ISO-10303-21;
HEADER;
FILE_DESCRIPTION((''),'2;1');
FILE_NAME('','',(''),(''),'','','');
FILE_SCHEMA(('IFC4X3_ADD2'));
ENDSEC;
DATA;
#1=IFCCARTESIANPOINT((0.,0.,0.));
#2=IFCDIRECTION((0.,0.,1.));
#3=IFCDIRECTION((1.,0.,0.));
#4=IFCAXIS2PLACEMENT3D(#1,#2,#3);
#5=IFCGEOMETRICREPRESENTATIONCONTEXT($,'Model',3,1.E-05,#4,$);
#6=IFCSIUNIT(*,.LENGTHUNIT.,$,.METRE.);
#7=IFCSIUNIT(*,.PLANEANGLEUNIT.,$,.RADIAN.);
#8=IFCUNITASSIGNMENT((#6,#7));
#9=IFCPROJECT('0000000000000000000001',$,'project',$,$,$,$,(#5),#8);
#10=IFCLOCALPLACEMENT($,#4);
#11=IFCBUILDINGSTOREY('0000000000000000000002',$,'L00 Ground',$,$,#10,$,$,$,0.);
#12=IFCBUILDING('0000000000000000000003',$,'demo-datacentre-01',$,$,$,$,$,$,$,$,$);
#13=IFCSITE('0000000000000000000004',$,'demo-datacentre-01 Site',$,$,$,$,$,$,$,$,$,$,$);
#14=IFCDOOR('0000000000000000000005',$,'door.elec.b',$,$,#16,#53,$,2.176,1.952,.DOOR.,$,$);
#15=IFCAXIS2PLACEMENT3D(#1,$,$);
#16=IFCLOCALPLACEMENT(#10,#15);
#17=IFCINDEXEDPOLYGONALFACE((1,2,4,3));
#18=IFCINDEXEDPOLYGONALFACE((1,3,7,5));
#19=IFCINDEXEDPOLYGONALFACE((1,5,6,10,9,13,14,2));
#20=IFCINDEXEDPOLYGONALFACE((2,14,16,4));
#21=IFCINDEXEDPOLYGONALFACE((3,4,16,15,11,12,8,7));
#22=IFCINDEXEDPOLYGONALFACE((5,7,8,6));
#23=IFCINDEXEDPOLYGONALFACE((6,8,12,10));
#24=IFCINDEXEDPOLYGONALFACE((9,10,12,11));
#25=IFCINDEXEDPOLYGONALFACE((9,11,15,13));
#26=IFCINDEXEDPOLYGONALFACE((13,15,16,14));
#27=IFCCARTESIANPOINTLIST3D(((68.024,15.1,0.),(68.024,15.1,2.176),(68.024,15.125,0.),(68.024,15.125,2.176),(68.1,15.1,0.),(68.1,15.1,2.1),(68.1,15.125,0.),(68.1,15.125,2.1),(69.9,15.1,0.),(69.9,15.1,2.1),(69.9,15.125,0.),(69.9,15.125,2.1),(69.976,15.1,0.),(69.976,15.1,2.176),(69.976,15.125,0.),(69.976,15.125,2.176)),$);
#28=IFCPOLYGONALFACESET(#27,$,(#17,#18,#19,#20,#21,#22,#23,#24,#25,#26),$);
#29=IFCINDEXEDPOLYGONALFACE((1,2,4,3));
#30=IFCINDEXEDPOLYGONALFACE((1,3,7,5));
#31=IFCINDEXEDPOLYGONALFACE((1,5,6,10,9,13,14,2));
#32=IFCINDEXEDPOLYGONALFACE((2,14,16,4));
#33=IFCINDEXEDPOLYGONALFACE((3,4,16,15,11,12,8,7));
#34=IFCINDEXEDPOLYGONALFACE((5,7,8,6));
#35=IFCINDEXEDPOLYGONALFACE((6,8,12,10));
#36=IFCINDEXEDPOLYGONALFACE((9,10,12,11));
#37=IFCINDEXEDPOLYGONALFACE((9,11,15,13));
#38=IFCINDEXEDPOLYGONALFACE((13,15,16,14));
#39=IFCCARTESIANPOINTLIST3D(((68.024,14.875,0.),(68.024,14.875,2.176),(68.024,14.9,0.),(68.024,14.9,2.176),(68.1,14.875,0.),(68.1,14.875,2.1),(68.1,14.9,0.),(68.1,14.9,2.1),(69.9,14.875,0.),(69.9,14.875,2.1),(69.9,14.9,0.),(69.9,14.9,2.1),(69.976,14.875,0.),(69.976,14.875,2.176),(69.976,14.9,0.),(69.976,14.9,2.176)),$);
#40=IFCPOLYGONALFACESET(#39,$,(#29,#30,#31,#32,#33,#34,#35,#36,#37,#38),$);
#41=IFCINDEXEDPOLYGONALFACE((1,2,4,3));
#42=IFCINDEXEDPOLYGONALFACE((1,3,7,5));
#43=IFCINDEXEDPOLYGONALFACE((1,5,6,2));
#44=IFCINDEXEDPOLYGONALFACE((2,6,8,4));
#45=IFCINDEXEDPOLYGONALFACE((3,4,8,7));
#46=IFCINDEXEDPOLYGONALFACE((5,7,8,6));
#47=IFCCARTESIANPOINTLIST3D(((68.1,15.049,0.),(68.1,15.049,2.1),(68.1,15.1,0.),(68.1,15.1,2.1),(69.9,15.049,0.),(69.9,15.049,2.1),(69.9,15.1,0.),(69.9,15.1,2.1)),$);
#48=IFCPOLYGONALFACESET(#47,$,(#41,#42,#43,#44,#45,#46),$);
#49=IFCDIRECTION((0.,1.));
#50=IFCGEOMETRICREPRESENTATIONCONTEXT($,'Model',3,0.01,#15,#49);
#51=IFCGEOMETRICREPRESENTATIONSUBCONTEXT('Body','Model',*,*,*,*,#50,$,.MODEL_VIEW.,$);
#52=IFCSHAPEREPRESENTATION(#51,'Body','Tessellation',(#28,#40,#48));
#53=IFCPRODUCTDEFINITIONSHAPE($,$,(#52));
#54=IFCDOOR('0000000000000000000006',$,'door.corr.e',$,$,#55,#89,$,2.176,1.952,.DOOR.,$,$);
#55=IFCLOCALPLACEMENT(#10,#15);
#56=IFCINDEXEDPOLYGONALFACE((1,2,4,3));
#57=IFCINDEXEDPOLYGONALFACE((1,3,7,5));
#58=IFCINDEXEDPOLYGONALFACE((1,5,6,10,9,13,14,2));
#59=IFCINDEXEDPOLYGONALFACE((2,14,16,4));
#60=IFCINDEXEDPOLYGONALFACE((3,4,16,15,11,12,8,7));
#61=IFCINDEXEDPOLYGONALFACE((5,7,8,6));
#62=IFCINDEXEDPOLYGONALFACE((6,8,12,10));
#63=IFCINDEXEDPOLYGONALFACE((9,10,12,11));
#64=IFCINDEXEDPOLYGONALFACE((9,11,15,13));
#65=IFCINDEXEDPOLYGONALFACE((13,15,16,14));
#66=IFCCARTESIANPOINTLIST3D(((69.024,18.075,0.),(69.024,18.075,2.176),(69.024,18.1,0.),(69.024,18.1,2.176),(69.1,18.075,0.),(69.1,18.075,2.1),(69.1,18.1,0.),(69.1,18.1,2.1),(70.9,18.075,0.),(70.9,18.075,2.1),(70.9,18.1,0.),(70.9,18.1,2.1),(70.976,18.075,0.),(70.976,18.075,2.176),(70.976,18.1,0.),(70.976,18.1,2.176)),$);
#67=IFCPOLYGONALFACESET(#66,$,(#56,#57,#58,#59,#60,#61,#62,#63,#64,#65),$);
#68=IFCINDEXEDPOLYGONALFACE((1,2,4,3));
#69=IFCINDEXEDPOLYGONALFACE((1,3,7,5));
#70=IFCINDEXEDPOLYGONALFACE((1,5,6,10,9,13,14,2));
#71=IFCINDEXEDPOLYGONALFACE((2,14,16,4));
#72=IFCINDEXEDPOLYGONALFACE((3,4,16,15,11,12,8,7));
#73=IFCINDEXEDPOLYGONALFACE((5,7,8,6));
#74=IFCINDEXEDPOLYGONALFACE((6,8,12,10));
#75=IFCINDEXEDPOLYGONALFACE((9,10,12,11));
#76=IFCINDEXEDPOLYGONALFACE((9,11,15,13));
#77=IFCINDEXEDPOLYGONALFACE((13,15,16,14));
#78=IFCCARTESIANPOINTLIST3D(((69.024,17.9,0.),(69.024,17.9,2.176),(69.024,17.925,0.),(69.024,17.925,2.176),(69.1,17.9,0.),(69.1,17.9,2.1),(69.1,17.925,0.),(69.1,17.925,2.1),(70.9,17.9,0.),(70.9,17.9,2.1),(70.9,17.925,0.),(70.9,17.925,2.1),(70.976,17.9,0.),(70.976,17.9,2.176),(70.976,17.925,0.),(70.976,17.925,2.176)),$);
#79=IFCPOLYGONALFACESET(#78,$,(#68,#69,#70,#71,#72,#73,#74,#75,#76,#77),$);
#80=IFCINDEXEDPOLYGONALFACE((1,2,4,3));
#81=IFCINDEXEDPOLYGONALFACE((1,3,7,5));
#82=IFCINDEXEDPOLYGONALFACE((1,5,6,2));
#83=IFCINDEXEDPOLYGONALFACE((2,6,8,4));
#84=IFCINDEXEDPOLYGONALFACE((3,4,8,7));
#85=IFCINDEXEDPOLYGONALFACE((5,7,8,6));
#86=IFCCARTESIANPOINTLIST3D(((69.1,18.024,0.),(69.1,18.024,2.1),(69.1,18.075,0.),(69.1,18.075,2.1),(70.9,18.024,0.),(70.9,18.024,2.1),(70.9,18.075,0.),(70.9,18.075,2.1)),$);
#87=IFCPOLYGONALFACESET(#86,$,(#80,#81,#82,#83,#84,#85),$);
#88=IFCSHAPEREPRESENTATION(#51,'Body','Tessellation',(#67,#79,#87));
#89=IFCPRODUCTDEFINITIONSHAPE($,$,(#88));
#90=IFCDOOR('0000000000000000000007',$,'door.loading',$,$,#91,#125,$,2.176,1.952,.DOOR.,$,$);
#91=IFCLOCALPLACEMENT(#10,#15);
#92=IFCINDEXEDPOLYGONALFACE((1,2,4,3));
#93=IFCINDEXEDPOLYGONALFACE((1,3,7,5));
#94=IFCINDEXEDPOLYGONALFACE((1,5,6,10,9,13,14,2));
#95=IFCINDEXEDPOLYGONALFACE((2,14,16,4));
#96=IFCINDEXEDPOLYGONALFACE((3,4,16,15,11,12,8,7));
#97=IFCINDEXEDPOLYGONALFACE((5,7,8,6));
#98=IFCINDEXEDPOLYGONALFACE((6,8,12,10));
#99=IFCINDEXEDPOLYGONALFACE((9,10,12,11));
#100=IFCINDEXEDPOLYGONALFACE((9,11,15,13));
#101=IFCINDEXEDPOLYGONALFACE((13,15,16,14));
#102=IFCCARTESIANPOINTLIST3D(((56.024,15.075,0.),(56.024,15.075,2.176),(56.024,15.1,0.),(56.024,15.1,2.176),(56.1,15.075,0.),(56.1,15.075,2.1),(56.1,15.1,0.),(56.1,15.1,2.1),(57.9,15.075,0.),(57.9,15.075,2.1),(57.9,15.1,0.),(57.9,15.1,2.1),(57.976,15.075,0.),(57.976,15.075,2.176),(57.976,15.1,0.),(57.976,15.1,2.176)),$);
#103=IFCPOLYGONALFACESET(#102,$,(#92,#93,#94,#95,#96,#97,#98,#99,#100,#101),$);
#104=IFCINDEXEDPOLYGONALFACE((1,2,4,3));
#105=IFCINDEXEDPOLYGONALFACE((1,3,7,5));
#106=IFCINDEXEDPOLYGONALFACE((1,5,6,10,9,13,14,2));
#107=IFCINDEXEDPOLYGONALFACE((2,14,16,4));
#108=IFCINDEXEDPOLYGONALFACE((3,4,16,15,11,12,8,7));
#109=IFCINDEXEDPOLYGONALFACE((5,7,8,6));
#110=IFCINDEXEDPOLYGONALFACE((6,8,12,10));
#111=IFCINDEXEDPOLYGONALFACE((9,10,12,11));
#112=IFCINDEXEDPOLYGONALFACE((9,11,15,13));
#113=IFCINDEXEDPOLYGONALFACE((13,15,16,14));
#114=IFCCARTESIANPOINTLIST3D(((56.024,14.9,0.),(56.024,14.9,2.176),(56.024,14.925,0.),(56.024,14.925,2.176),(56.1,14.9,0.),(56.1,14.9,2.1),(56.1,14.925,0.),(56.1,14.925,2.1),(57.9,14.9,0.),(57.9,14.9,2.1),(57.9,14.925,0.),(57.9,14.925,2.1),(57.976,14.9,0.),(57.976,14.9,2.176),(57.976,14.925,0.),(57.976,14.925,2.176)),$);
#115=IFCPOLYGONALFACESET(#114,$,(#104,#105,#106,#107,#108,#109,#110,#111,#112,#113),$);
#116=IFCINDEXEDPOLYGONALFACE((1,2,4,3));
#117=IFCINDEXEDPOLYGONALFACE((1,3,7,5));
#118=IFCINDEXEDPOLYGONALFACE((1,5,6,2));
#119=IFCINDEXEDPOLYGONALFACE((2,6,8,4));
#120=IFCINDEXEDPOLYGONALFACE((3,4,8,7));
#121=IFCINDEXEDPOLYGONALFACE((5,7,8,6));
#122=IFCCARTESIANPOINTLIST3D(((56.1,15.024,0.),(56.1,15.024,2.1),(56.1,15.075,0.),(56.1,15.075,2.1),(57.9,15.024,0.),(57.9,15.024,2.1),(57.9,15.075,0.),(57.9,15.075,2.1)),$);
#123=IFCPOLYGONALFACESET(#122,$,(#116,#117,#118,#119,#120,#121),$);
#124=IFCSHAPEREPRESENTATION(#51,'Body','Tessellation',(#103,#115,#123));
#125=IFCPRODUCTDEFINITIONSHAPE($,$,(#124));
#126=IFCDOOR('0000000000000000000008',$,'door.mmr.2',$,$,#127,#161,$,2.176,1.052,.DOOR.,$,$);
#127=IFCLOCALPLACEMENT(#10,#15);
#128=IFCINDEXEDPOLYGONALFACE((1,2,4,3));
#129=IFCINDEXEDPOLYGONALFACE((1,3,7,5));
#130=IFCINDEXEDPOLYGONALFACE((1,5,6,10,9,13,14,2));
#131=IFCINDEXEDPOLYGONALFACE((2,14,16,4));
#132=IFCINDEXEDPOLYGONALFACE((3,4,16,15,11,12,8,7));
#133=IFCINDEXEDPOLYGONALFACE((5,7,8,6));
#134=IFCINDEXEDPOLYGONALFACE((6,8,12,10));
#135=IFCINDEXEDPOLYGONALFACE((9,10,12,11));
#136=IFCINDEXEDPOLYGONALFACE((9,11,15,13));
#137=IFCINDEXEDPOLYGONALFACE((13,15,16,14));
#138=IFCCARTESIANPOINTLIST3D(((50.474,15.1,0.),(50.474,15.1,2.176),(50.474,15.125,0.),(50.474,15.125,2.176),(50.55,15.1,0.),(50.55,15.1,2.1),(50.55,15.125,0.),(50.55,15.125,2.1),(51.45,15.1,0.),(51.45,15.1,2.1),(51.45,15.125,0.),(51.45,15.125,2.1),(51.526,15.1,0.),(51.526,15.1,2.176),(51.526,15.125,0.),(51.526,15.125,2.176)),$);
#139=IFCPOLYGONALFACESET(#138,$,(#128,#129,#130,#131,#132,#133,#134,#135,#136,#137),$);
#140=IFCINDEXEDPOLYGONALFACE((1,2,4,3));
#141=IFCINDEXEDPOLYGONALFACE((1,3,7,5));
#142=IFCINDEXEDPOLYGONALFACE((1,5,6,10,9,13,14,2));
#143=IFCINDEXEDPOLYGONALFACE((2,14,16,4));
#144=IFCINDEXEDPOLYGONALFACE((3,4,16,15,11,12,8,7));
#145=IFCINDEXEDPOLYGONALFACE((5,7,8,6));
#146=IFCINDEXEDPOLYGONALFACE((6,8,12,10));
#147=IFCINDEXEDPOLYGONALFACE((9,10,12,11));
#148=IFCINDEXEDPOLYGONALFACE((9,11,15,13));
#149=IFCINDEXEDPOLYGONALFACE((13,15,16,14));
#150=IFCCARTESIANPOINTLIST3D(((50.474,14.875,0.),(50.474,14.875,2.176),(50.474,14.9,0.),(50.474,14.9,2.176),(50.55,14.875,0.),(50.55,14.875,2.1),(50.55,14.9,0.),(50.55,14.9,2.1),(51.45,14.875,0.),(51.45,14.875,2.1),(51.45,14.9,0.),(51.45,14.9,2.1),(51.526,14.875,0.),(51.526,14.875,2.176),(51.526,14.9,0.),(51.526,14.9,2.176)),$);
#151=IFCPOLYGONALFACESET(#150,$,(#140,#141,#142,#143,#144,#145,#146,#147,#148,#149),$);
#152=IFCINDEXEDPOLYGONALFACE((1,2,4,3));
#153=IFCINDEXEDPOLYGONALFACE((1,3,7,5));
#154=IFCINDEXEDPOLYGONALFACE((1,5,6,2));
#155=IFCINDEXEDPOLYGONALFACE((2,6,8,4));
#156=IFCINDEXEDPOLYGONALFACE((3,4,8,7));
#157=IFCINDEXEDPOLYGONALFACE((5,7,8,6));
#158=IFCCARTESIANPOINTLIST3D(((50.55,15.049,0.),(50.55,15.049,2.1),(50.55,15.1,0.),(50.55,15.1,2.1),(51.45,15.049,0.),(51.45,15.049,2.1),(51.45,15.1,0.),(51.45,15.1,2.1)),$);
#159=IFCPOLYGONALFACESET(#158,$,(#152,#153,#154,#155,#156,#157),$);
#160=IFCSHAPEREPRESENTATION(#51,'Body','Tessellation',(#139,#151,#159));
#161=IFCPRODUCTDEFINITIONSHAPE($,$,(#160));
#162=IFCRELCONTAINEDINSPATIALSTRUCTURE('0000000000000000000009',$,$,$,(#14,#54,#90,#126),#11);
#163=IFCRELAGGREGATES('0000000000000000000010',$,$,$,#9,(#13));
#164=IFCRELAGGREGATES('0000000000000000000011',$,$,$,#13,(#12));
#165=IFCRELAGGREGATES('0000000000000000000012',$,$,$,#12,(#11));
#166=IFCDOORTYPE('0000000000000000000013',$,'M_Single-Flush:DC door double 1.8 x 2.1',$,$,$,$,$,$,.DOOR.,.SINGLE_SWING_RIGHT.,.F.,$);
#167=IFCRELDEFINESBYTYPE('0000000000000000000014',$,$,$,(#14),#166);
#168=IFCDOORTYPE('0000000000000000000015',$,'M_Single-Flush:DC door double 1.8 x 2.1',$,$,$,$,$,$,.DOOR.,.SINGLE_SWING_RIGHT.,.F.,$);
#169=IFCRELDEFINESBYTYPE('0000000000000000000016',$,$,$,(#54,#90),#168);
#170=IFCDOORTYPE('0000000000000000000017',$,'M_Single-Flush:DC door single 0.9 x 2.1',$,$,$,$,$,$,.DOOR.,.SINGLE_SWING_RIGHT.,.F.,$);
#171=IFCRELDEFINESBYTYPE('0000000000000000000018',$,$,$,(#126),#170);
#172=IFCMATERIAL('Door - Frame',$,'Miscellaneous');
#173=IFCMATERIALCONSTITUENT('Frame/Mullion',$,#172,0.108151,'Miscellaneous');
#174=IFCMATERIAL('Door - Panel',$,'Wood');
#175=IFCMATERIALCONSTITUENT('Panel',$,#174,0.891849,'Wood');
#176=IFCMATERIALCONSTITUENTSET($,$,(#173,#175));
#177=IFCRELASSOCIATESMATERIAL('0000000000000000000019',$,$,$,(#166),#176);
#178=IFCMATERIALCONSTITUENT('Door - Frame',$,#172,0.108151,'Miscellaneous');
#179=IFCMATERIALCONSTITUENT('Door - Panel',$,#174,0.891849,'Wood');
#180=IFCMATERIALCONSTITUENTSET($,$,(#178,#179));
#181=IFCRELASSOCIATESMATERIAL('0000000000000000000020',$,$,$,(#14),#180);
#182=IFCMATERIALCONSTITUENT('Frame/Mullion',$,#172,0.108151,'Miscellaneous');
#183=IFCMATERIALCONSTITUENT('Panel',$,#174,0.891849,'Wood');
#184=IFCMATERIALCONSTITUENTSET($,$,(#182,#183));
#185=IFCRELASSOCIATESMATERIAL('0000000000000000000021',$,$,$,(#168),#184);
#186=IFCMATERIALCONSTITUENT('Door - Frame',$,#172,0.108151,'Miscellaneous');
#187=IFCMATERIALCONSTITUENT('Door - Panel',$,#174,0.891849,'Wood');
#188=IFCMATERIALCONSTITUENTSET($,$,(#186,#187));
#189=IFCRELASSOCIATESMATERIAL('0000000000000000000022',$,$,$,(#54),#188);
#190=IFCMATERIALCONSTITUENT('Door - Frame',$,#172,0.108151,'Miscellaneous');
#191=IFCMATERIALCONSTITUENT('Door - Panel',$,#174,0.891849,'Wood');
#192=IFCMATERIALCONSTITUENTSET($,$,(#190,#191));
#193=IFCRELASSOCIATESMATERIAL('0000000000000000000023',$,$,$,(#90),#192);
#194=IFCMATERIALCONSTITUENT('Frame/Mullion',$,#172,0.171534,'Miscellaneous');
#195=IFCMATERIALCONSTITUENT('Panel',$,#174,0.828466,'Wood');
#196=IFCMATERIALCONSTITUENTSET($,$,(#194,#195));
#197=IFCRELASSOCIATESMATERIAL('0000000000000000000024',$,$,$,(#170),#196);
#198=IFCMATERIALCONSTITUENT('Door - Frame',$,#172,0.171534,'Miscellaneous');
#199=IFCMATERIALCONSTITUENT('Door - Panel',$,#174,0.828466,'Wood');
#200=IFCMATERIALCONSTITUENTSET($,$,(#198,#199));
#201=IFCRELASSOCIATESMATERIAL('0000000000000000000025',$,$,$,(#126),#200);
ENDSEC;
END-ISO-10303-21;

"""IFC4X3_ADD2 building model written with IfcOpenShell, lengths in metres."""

from ifc_helpers import new_model, si_unit, direction, frame, frame_2d, origin, origin_with_axes, place, context, subcontext, project, spatial, polyline, rectangle, outline, extrude, source, transform, mapped, material, constituent, constituent_set, type_object, type_shapes, element, save


model = new_model("IFC4X3_ADD2")

# Units and contexts
model_context_1 = context("Model", 3, precision=0.01, world=origin(), true_north=direction((0.0, 1.0)))
model_context_2 = context("Model", 3, precision=1e-05, world=origin_with_axes())
body_context = subcontext(model_context_1, "Body", "Model", "MODEL_VIEW")
ifc_project = project(units=[si_unit("LENGTHUNIT", "METRE"), si_unit("PLANEANGLEUNIT", "RADIAN")], contexts=[model_context_2])

# Site, building, storey
site = spatial("IfcSite", under=ifc_project, Name="demo-datacentre-01 Site")
building = spatial("IfcBuilding", under=site, Name="demo-datacentre-01")
storey_placement = place(None, origin_with_axes())
storey = spatial("IfcBuildingStorey", under=building, at=storey_placement, Name="L00 Ground", Elevation=0.0)

# Shared definitions
placement_1 = place(None, origin())
placement_2 = place(placement_1, origin())
placement_3 = place(placement_2, origin())

# Doors
ifc_material_1 = material(Name="Door - Frame", Category="Miscellaneous")
ifc_material_2 = material(Name="Door - Panel", Category="Wood")
ifc_constituent_1 = constituent(ifc_material_1, Name="Frame/Mullion", Category="Miscellaneous", fraction=0.108151)
ifc_constituent_2 = constituent(ifc_material_2, Name="Panel", Category="Wood", fraction=0.891849)
ifc_constituent_set_1 = constituent_set(constituents=[ifc_constituent_1, ifc_constituent_2])
door_type_1 = type_object("IfcDoorType", Name="M_Single-Flush:DC door double 1.8 x 2.1", OperationType="SINGLE_SWING_RIGHT", ParameterTakesPrecedence=False, PredefinedType="DOOR", material=ifc_constituent_set_1)
shared_shape_1 = source(origin(), body_context, "Body", "SweptSolid", [
    extrude(outline(polyline([(-0.976, -1.107), (0.976, -1.107), (0.976, 1.069), (0.9, 1.069), (0.9, -1.031), (-0.9, -1.031), (-0.9, 1.069), (-0.976, 1.069), (-0.976, -1.107)])), frame((0.9, 0.2, 1.069), z_axis=(0.0, 1.0, 0.0), x_axis=(1.0, 0.0, 0.0)), (0.0, 0.0, 1.0), 0.025),
    extrude(outline(polyline([(-1.107, -0.976), (1.069, -0.976), (1.069, -0.9), (-1.031, -0.9), (-1.031, 0.9), (1.069, 0.9), (1.069, 0.976), (-1.107, 0.976), (-1.107, -0.976)])), frame((0.9, -0.025, 1.069), z_axis=(0.0, 1.0, 0.0), x_axis=(0.0, 0.0, -1.0)), (0.0, 0.0, 1.0), 0.025),
    extrude(rectangle(XDim=0.051, YDim=1.8, at=frame_2d((0.0, 0.0), x_axis=(1.0, 0.0))), frame((0.9, 0.1745, 0.0), z_axis=(0.0, 0.0, 1.0), x_axis=(0.0, 1.0, 0.0)), (0.0, 0.0, 1.0), 2.1),
])
type_shapes(door_type_1, [shared_shape_1])
ifc_constituent_3 = constituent(ifc_material_1, Name="Door - Frame", Category="Miscellaneous", fraction=0.108151)
ifc_constituent_4 = constituent(ifc_material_2, Name="Door - Panel", Category="Wood", fraction=0.891849)
ifc_constituent_set_2 = constituent_set(constituents=[ifc_constituent_3, ifc_constituent_4])
door_1_placement = place(placement_3, frame((68.1, 14.9, 0.0)))
element("IfcDoor", 1, at=door_1_placement, inside=storey, type_object=door_type_1, material=ifc_constituent_set_2, Name="door.elec.b", OverallHeight=2.176, OverallWidth=1.952, PredefinedType="DOOR", context=body_context, shape_type="MappedRepresentation", body=[
    mapped(shared_shape_1, transform((0.0, 0.0, 0.0), scale=1.0)),
])
ifc_constituent_5 = constituent(ifc_material_1, Name="Door - Frame", Category="Miscellaneous", fraction=0.108151)
ifc_constituent_6 = constituent(ifc_material_2, Name="Door - Panel", Category="Wood", fraction=0.891849)
ifc_constituent_set_3 = constituent_set(constituents=[ifc_constituent_5, ifc_constituent_6])
ifc_constituent_7 = constituent(ifc_material_1, Name="Frame/Mullion", Category="Miscellaneous", fraction=0.108151)
ifc_constituent_8 = constituent(ifc_material_2, Name="Panel", Category="Wood", fraction=0.891849)
ifc_constituent_set_4 = constituent_set(constituents=[ifc_constituent_7, ifc_constituent_8])
door_type_2 = type_object("IfcDoorType", Name="M_Single-Flush:DC door double 1.8 x 2.1", OperationType="SINGLE_SWING_RIGHT", ParameterTakesPrecedence=False, PredefinedType="DOOR", material=ifc_constituent_set_4)
shared_shape_2 = source(origin(), body_context, "Body", "SweptSolid", [
    extrude(outline(polyline([(-0.976, -1.107), (0.976, -1.107), (0.976, 1.069), (0.9, 1.069), (0.9, -1.031), (-0.9, -1.031), (-0.9, 1.069), (-0.976, 1.069), (-0.976, -1.107)])), frame((0.9, 0.15, 1.069), z_axis=(0.0, 1.0, 0.0), x_axis=(1.0, 0.0, 0.0)), (0.0, 0.0, 1.0), 0.025),
    extrude(outline(polyline([(-1.107, -0.976), (1.069, -0.976), (1.069, -0.9), (-1.031, -0.9), (-1.031, 0.9), (1.069, 0.9), (1.069, 0.976), (-1.107, 0.976), (-1.107, -0.976)])), frame((0.9, -0.025, 1.069), z_axis=(0.0, 1.0, 0.0), x_axis=(0.0, 0.0, -1.0)), (0.0, 0.0, 1.0), 0.025),
    extrude(rectangle(XDim=0.051, YDim=1.8, at=frame_2d((0.0, 0.0), x_axis=(1.0, 0.0))), frame((0.9, 0.1245, 0.0), z_axis=(0.0, 0.0, 1.0), x_axis=(0.0, 1.0, 0.0)), (0.0, 0.0, 1.0), 2.1),
])
type_shapes(door_type_2, [shared_shape_2])
door_2_placement = place(placement_3, frame((69.1, 17.925, 0.0)))
element("IfcDoor", 2, at=door_2_placement, inside=storey, type_object=door_type_2, material=ifc_constituent_set_3, Name="door.corr.e", OverallHeight=2.176, OverallWidth=1.952, PredefinedType="DOOR", context=body_context, shape_type="MappedRepresentation", body=[
    mapped(shared_shape_2, transform((0.0, 0.0, 0.0), scale=1.0)),
])
ifc_constituent_9 = constituent(ifc_material_1, Name="Door - Frame", Category="Miscellaneous", fraction=0.108151)
ifc_constituent_10 = constituent(ifc_material_2, Name="Door - Panel", Category="Wood", fraction=0.891849)
ifc_constituent_set_5 = constituent_set(constituents=[ifc_constituent_9, ifc_constituent_10])
door_3_placement = place(placement_3, frame((56.1, 14.925, 0.0)))
element("IfcDoor", 3, at=door_3_placement, inside=storey, type_object=door_type_2, material=ifc_constituent_set_5, Name="door.loading", OverallHeight=2.176, OverallWidth=1.952, PredefinedType="DOOR", context=body_context, shape_type="MappedRepresentation", body=[
    mapped(shared_shape_2, transform((0.0, 0.0, 0.0), scale=1.0)),
])
ifc_constituent_11 = constituent(ifc_material_1, Name="Door - Frame", Category="Miscellaneous", fraction=0.171534)
ifc_constituent_12 = constituent(ifc_material_2, Name="Door - Panel", Category="Wood", fraction=0.828466)
ifc_constituent_set_6 = constituent_set(constituents=[ifc_constituent_11, ifc_constituent_12])
ifc_constituent_13 = constituent(ifc_material_1, Name="Frame/Mullion", Category="Miscellaneous", fraction=0.171534)
ifc_constituent_14 = constituent(ifc_material_2, Name="Panel", Category="Wood", fraction=0.828466)
ifc_constituent_set_7 = constituent_set(constituents=[ifc_constituent_13, ifc_constituent_14])
door_type_3 = type_object("IfcDoorType", Name="M_Single-Flush:DC door single 0.9 x 2.1", OperationType="SINGLE_SWING_RIGHT", ParameterTakesPrecedence=False, PredefinedType="DOOR", material=ifc_constituent_set_7)
shared_shape_3 = source(origin(), body_context, "Body", "SweptSolid", [
    extrude(outline(polyline([(-0.526, -1.107), (0.526, -1.107), (0.526, 1.069), (0.45, 1.069), (0.45, -1.031), (-0.45, -1.031), (-0.45, 1.069), (-0.526, 1.069), (-0.526, -1.107)])), frame((0.45, 0.2, 1.069), z_axis=(0.0, 1.0, 0.0), x_axis=(1.0, 0.0, 0.0)), (0.0, 0.0, 1.0), 0.025),
    extrude(outline(polyline([(-1.107, -0.526), (1.069, -0.526), (1.069, -0.45), (-1.031, -0.45), (-1.031, 0.45), (1.069, 0.45), (1.069, 0.526), (-1.107, 0.526), (-1.107, -0.526)])), frame((0.45, -0.025, 1.069), z_axis=(0.0, 1.0, 0.0), x_axis=(0.0, 0.0, -1.0)), (0.0, 0.0, 1.0), 0.025),
    extrude(rectangle(XDim=0.051, YDim=0.9, at=frame_2d((0.0, 0.0), x_axis=(1.0, 0.0))), frame((0.45, 0.1745, 0.0), z_axis=(0.0, 0.0, 1.0), x_axis=(0.0, 1.0, 0.0)), (0.0, 0.0, 1.0), 2.1),
])
type_shapes(door_type_3, [shared_shape_3])
door_4_placement = place(placement_3, frame((50.55, 14.9, 0.0)))
element("IfcDoor", 4, at=door_4_placement, inside=storey, type_object=door_type_3, material=ifc_constituent_set_6, Name="door.mmr.2", OverallHeight=2.176, OverallWidth=1.052, PredefinedType="DOOR", context=body_context, shape_type="MappedRepresentation", body=[
    mapped(shared_shape_3, transform((0.0, 0.0, 0.0), scale=1.0)),
])

save(model, "model.ifc")
